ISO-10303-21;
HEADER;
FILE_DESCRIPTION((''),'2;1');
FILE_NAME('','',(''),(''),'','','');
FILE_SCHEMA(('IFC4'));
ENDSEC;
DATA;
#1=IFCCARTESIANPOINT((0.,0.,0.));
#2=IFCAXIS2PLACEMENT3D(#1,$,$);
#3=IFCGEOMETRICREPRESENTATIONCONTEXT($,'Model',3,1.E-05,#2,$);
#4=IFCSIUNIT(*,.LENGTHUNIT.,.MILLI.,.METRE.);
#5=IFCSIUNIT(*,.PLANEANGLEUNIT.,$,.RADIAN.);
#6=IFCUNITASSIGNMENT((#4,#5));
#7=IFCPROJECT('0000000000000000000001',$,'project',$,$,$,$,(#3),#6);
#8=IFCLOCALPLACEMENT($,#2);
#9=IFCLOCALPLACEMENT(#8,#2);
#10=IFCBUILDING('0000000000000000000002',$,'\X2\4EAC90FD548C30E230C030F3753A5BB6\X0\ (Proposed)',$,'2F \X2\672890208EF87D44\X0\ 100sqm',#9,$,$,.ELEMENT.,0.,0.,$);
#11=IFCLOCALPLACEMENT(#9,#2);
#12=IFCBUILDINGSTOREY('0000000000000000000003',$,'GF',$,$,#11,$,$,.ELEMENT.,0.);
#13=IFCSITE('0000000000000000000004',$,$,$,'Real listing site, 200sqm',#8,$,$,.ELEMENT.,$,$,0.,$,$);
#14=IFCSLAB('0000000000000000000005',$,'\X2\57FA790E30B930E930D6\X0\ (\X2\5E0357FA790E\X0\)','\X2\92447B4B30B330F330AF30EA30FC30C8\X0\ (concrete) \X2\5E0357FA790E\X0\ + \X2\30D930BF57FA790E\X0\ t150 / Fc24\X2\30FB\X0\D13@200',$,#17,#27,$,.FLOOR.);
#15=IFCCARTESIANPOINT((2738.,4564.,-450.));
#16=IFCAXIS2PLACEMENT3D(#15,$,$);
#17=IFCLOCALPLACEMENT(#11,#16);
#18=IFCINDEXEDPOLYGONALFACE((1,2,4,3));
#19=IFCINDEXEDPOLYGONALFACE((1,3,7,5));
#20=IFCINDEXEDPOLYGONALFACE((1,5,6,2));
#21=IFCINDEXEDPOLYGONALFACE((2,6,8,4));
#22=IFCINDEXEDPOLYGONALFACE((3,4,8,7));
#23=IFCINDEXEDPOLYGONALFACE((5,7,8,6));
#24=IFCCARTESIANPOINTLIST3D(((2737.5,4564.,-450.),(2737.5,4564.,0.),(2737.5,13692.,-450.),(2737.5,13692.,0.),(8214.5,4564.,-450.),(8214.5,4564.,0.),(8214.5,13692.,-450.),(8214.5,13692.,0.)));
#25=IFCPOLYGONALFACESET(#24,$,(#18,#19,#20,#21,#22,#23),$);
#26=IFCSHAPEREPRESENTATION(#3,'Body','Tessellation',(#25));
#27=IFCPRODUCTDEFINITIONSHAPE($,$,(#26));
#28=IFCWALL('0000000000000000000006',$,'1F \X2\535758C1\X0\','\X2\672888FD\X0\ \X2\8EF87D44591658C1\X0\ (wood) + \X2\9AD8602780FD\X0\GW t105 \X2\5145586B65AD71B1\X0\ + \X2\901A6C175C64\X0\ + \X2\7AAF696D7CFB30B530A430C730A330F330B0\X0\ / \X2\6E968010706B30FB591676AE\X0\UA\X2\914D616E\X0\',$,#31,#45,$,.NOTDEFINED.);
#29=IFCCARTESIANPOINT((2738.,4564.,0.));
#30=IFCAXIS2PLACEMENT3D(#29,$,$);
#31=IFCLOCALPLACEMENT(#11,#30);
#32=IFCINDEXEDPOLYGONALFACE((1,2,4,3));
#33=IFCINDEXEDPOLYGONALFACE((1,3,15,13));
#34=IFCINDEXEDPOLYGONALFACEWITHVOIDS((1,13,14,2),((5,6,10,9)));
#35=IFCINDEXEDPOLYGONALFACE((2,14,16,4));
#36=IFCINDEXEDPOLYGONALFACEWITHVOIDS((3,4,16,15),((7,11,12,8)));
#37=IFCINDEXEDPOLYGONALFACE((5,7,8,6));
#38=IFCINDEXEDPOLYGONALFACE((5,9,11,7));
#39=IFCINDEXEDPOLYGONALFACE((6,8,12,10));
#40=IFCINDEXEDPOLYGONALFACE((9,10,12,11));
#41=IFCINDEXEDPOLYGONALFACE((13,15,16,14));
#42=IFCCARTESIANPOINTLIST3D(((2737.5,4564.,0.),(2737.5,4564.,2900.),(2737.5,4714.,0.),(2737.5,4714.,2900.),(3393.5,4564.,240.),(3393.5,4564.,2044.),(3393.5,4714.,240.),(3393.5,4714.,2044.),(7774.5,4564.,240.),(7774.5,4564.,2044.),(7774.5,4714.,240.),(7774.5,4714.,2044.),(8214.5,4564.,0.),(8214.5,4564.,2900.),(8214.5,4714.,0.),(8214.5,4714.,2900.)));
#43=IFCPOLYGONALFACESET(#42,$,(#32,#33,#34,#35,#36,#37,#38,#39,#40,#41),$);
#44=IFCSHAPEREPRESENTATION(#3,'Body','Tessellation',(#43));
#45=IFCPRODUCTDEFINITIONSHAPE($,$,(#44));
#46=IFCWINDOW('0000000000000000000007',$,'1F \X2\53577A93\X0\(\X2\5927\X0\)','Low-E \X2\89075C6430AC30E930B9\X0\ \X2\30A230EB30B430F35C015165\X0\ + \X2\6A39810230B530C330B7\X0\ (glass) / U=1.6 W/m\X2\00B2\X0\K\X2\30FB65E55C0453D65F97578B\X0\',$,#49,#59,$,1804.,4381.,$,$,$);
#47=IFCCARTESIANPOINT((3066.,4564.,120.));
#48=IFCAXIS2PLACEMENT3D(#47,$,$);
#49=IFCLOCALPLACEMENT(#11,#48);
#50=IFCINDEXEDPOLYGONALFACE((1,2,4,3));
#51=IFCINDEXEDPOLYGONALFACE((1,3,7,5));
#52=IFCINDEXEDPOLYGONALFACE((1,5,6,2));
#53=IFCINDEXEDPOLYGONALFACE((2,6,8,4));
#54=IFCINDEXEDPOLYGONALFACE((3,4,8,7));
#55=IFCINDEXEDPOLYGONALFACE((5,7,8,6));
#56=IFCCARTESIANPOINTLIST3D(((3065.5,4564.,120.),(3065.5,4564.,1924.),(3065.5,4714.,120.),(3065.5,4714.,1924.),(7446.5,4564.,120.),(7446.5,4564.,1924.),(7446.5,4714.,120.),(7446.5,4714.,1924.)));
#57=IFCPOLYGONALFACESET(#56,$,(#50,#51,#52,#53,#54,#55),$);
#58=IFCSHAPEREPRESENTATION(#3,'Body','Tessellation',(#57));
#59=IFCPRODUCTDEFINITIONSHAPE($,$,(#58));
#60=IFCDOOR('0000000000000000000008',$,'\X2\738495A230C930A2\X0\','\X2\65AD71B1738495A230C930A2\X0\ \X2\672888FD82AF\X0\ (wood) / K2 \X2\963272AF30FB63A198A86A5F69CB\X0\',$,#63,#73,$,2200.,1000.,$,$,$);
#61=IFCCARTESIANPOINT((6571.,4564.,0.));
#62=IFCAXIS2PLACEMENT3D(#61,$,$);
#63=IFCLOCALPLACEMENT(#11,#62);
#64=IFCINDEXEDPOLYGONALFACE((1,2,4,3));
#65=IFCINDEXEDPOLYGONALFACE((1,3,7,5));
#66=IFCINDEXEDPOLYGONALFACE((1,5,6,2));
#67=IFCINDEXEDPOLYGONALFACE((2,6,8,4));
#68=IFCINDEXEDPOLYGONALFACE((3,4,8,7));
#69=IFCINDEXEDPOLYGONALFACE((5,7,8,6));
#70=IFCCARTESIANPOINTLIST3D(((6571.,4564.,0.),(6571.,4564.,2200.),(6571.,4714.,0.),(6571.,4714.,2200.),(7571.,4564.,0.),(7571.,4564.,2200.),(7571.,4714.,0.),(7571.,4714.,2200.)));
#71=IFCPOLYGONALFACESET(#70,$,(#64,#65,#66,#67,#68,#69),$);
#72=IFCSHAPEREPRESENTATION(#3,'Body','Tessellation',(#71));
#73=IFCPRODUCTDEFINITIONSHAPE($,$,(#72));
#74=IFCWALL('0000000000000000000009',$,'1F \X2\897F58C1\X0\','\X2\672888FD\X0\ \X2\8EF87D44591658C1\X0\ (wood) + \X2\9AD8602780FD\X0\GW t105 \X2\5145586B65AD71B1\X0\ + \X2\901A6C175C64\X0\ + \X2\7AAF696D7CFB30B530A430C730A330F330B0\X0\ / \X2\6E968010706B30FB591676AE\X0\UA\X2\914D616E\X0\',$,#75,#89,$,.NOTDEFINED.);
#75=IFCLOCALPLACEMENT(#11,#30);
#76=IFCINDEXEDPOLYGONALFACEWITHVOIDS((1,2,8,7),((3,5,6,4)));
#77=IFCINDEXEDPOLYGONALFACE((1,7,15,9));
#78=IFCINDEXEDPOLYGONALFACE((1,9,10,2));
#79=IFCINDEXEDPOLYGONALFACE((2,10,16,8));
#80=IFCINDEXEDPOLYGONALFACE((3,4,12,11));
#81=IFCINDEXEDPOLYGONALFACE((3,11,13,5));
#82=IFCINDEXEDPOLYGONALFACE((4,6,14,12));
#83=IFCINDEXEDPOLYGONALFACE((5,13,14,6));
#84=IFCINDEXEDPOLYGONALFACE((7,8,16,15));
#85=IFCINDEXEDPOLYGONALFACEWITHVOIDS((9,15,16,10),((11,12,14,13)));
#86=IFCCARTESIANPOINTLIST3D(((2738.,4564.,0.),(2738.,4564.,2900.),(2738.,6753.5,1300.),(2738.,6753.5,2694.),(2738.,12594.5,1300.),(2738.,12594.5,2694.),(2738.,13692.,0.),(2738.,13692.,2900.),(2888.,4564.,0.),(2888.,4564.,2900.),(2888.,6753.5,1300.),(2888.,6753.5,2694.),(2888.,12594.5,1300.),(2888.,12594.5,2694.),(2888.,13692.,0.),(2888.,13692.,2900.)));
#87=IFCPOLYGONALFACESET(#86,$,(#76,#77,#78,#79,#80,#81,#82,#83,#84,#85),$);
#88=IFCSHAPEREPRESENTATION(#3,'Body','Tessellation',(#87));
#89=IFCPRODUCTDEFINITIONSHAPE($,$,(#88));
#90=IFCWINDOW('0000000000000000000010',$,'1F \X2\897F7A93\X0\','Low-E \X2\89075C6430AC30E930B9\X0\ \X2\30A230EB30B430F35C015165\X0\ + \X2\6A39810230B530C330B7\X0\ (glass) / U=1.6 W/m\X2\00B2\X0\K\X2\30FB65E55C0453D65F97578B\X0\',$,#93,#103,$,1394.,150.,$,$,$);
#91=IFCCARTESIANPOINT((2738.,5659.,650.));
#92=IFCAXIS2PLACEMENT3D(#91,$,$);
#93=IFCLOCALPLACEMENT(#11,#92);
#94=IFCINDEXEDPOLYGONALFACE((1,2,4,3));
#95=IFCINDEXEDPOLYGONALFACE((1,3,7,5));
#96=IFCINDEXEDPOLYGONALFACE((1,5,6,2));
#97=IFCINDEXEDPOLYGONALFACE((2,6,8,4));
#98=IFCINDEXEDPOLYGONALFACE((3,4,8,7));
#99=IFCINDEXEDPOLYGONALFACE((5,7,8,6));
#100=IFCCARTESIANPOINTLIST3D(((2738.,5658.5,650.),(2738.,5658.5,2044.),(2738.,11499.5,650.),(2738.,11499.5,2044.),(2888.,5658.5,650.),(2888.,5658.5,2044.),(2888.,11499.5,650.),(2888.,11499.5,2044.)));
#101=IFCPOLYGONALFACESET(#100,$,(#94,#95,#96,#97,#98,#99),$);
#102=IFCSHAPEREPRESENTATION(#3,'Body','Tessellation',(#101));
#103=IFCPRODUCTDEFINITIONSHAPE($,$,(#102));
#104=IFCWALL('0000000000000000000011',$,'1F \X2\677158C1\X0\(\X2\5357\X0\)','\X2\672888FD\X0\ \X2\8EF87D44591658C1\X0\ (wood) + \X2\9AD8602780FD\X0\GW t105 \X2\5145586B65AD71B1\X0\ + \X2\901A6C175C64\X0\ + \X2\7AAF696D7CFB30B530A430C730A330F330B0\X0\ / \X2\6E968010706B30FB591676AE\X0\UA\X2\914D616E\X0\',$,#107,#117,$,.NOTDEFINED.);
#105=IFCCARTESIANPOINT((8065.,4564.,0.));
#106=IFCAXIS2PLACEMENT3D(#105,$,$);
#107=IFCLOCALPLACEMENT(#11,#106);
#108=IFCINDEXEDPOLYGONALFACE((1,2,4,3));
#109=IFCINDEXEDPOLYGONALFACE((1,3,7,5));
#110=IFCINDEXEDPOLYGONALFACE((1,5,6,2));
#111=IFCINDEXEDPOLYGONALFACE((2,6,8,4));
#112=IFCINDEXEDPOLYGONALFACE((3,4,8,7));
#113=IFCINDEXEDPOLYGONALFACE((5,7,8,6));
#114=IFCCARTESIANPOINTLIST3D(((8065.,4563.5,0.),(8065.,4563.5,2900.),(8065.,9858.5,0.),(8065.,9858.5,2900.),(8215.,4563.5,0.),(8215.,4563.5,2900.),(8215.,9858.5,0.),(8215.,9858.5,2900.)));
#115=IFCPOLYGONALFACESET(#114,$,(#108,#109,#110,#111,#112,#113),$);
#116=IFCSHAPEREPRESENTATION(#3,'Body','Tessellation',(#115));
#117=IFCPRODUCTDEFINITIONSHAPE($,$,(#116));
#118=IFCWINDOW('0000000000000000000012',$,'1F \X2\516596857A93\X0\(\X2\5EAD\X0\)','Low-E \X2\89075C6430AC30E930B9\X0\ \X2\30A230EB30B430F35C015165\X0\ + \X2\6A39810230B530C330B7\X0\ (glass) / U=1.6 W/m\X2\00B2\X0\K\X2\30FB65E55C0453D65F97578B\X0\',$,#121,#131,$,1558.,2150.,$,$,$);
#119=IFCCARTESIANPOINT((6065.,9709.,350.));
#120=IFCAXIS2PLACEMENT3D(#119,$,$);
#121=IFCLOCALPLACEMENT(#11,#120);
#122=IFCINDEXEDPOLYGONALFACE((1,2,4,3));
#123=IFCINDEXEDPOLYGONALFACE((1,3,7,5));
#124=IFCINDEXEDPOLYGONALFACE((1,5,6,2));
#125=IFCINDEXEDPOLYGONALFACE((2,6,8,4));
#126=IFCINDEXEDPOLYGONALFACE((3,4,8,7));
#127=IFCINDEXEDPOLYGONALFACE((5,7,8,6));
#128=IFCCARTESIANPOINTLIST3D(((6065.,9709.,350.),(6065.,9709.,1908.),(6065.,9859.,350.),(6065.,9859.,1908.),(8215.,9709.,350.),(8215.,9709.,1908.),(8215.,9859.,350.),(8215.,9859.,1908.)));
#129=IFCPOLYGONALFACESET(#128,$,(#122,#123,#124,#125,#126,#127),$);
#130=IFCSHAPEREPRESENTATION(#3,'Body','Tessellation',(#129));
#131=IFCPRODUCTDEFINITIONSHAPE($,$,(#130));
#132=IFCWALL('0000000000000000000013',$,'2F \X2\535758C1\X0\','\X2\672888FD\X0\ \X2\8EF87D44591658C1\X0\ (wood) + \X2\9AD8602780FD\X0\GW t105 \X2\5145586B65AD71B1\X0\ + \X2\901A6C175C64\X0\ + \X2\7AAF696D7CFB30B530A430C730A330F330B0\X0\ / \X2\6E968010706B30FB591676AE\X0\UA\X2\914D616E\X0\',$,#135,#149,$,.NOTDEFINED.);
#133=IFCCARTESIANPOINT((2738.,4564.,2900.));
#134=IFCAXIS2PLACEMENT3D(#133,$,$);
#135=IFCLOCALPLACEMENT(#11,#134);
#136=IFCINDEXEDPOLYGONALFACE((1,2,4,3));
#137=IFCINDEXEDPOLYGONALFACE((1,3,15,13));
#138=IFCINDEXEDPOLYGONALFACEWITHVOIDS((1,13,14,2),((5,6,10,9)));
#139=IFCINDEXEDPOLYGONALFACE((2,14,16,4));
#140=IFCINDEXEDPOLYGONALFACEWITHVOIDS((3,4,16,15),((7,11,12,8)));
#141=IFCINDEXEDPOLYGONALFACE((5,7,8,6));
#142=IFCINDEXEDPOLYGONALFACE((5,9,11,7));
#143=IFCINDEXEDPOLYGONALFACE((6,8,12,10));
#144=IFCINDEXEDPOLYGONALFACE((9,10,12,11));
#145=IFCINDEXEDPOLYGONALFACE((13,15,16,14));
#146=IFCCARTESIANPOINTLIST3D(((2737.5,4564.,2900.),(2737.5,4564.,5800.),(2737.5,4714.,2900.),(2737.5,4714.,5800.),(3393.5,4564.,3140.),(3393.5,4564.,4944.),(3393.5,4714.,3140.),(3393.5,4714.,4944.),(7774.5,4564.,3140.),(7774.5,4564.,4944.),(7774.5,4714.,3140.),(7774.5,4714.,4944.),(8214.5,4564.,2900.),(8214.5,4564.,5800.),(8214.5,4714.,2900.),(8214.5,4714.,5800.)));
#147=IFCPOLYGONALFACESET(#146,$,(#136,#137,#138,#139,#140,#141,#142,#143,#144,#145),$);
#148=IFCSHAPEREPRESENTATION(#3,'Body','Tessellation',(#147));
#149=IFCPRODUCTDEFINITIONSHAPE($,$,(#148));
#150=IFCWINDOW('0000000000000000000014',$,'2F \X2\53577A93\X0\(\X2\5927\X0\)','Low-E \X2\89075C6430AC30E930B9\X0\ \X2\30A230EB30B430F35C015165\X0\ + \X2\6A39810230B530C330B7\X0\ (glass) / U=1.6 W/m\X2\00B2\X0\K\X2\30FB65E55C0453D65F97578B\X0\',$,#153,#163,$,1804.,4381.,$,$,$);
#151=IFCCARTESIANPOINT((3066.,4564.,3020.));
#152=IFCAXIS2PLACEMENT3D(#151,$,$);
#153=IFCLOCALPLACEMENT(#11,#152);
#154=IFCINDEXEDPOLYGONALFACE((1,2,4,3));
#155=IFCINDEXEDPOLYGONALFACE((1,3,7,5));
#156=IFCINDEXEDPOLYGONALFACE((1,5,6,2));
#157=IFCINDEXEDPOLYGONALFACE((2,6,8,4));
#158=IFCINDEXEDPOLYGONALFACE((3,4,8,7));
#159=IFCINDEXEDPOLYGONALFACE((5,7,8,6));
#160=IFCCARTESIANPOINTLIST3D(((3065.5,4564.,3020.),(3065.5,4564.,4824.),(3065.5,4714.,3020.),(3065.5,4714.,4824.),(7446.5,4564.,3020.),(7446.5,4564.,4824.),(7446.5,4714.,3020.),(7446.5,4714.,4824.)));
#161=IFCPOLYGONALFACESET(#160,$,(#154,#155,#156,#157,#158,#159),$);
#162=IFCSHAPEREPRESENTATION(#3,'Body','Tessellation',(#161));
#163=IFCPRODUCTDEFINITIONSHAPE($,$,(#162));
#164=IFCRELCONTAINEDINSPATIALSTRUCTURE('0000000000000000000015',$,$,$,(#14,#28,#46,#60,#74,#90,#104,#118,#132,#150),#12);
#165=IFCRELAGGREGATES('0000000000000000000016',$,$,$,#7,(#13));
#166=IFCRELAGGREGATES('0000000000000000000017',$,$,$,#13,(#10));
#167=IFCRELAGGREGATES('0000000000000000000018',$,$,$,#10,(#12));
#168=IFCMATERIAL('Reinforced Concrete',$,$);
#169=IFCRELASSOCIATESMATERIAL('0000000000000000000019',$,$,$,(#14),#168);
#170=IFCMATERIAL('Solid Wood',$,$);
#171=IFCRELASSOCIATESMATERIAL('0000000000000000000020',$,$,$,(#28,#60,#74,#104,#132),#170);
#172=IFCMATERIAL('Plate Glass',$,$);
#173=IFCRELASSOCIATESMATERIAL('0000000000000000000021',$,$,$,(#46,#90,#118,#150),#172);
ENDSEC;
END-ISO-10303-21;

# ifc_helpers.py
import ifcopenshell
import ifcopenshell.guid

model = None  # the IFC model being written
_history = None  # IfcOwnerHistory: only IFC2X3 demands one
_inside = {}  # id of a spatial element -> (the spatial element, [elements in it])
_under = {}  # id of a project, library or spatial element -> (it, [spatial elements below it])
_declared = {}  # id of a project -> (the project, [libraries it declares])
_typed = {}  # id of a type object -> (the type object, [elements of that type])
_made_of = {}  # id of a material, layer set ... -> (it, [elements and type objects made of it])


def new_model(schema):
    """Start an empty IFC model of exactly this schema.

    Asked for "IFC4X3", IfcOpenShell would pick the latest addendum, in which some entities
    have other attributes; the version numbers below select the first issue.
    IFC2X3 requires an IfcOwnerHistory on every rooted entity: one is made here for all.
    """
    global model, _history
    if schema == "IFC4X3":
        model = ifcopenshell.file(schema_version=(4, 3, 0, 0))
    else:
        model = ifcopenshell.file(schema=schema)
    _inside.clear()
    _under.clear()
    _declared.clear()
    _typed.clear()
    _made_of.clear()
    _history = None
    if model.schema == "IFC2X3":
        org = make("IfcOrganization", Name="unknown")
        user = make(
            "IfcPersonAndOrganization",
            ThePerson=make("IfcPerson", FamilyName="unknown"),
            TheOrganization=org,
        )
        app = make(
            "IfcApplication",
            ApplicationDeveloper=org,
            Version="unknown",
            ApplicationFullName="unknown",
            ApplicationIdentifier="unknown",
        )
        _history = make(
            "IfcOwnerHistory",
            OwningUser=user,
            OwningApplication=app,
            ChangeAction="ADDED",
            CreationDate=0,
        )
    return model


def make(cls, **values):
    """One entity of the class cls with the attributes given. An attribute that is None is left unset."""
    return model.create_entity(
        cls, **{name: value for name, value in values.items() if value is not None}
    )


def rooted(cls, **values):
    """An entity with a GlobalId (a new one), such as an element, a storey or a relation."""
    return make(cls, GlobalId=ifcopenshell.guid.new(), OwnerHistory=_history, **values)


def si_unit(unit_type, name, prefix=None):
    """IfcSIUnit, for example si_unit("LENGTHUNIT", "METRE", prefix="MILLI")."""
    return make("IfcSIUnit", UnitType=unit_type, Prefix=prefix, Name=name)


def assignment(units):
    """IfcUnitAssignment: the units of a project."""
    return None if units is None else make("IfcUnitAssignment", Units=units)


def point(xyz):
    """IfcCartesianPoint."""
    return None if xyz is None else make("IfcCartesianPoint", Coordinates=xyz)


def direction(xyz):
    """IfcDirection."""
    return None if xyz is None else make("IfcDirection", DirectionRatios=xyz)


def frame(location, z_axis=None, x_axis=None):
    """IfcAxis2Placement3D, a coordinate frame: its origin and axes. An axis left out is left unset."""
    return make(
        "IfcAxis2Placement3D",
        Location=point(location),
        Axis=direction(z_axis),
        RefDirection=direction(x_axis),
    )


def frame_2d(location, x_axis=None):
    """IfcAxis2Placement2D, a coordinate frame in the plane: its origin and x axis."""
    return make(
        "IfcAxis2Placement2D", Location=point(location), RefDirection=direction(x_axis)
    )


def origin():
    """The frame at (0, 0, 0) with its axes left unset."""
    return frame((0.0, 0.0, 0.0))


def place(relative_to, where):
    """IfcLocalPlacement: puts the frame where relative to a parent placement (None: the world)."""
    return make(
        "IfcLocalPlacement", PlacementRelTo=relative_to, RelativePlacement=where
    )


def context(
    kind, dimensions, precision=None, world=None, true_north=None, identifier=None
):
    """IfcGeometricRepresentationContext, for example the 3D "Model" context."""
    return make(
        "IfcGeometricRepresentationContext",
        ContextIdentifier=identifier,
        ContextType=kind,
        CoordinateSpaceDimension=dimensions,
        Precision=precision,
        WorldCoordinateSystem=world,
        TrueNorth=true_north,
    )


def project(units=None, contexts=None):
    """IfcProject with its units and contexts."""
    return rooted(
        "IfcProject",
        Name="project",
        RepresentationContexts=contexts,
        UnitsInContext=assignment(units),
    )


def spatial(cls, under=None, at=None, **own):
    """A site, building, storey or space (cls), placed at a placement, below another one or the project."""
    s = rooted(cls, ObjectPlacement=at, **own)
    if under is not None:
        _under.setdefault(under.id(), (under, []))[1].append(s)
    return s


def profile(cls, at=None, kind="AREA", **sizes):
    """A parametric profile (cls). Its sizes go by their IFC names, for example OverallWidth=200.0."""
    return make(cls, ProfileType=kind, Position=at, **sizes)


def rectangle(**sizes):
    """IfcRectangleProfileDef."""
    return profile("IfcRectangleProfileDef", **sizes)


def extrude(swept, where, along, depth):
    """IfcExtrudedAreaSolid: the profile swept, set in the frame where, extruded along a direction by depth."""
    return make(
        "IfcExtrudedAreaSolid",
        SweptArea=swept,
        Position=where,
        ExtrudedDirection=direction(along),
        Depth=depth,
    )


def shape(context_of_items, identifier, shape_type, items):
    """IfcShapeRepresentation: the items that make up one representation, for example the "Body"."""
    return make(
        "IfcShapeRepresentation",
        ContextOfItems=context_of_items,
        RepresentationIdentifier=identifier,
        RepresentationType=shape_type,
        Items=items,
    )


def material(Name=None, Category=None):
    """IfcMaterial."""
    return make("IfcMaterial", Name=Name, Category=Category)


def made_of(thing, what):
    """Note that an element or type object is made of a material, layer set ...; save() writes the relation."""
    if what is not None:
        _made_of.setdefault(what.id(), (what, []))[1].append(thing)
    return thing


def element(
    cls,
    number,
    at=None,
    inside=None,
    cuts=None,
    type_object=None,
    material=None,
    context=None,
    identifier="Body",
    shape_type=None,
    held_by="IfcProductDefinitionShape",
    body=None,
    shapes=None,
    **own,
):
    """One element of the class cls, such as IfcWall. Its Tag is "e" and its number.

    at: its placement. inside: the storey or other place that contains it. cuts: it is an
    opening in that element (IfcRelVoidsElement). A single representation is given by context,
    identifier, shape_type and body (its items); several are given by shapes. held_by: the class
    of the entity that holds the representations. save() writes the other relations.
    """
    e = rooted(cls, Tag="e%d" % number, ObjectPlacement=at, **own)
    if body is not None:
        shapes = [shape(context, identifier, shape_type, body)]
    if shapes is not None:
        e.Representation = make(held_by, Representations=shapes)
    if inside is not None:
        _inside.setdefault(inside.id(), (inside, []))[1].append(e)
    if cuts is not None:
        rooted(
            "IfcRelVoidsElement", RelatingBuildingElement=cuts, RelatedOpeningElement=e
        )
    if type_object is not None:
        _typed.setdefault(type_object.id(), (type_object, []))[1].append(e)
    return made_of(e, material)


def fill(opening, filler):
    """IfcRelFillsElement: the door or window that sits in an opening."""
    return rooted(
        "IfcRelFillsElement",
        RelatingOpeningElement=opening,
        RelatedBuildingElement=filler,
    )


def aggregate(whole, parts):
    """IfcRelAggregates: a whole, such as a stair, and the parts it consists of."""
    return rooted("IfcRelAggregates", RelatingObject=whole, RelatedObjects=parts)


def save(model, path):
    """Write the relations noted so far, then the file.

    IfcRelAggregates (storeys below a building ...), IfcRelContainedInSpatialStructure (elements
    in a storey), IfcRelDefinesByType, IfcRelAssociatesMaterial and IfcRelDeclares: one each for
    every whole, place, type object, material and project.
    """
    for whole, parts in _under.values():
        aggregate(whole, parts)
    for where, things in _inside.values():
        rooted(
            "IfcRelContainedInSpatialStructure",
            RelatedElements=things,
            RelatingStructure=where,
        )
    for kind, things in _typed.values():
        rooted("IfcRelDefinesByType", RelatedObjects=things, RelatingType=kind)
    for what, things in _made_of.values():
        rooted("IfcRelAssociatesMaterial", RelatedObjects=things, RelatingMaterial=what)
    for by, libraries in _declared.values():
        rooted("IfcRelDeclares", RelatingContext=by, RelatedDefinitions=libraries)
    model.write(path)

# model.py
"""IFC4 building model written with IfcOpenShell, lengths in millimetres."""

from ifc_helpers import new_model, si_unit, frame, frame_2d, origin, place, context, project, spatial, rectangle, extrude, material, element, fill, save


model = new_model("IFC4")

# Units and contexts
model_context = context("Model", 3, precision=1e-05, world=origin())
ifc_project = project(units=[si_unit("LENGTHUNIT", "METRE", prefix="MILLI"), si_unit("PLANEANGLEUNIT", "RADIAN")], contexts=[model_context])

# Site, building, storey
site_placement = place(None, origin())
site = spatial("IfcSite", under=ifc_project, at=site_placement, ObjectType="Real listing site, 200sqm", CompositionType="ELEMENT", RefElevation=0.0)
building_placement = place(site_placement, origin())
building = spatial("IfcBuilding", under=site, at=building_placement, Name="京都和モダン町家 (Proposed)", ObjectType="2F 木造軸組 100sqm", CompositionType="ELEMENT", ElevationOfRefHeight=0.0, ElevationOfTerrain=0.0)
storey_placement = place(building_placement, origin())
storey = spatial("IfcBuildingStorey", under=building, at=storey_placement, Name="GF", CompositionType="ELEMENT", Elevation=0.0)

# Slab
ifc_material_1 = material(Name="Reinforced Concrete")
slab_1_placement = place(storey_placement, frame((2738.0, 4564.0, -450.0)))
element("IfcSlab", 1, at=slab_1_placement, inside=storey, material=ifc_material_1, Name="基礎スラブ (布基礎)", Description="鉄筋コンクリート (concrete) 布基礎 + ベタ基礎 t150 / Fc24・D13@200", PredefinedType="FLOOR", context=model_context, shape_type="SweptSolid", body=[
    extrude(rectangle(XDim=5477.0, YDim=9128.0, at=frame_2d((2738.0, 4564.0))), frame((2738.0, 4564.0, -450.0)), (0.0, 0.0, 1.0), 450.0),
])
ifc_material_2 = material(Name="Solid Wood")

# Wall, openings, window, door
wall_1_placement = place(storey_placement, frame((2738.0, 4564.0, 0.0)))
wall_1 = element("IfcWall", 2, at=wall_1_placement, inside=storey, material=ifc_material_2, Name="1F 南壁", Description="木製 軸組外壁 (wood) + 高性能GW t105 充填断熱 + 通気層 + 窯業系サイディング / 準耐火・外皮UA配慮", PredefinedType="NOTDEFINED", context=model_context, shape_type="SweptSolid", body=[
    extrude(rectangle(XDim=5477.0, YDim=150.0, at=frame_2d((2738.0, 75.0))), frame((2738.0, 4564.0, 0.0)), (0.0, 0.0, 1.0), 2900.0),
])
opening_1_placement = place(storey_placement, frame((3066.0, 4564.0, 120.0)))
opening_1 = element("IfcOpeningElement", 3, at=opening_1_placement, cuts=wall_1, PredefinedType="NOTDEFINED", context=model_context, shape_type="SweptSolid", body=[
    extrude(rectangle(XDim=4381.0, YDim=150.0, at=frame_2d((2190.0, 75.0))), frame((3066.0, 4564.0, 120.0)), (0.0, 0.0, 1.0), 1804.0),
])
opening_2_placement = place(storey_placement, frame((6571.0, 4564.0, 0.0)))
opening_2 = element("IfcOpeningElement", 4, at=opening_2_placement, cuts=wall_1, PredefinedType="NOTDEFINED", context=model_context, shape_type="SweptSolid", body=[
    extrude(rectangle(XDim=1000.0, YDim=150.0, at=frame_2d((500.0, 75.0))), frame((6571.0, 4564.0, 0.0)), (0.0, 0.0, 1.0), 2200.0),
])
ifc_material_3 = material(Name="Plate Glass")
window_1_placement = place(storey_placement, frame((3066.0, 4564.0, 120.0)))
window_1 = element("IfcWindow", 5, at=window_1_placement, inside=storey, material=ifc_material_3, Name="1F 南窓(大)", Description="Low-E 複層ガラス アルゴン封入 + 樹脂サッシ (glass) / U=1.6 W/m²K・日射取得型", OverallHeight=1804.0, OverallWidth=4381.0, context=model_context, shape_type="SweptSolid", body=[
    extrude(rectangle(XDim=4381.0, YDim=150.0, at=frame_2d((2190.0, 75.0))), frame((3066.0, 4564.0, 120.0)), (0.0, 0.0, 1.0), 1804.0),
])
fill(opening_1, window_1)
door_placement = place(storey_placement, frame((6571.0, 4564.0, 0.0)))
door = element("IfcDoor", 6, at=door_placement, inside=storey, material=ifc_material_2, Name="玄関ドア", Description="断熱玄関ドア 木製芯 (wood) / K2 防犯・採風機構", OverallHeight=2200.0, OverallWidth=1000.0, context=model_context, shape_type="SweptSolid", body=[
    extrude(rectangle(XDim=1000.0, YDim=150.0, at=frame_2d((500.0, 75.0))), frame((6571.0, 4564.0, 0.0)), (0.0, 0.0, 1.0), 2200.0),
])
fill(opening_2, door)

# Walls, openings, windows
wall_2_placement = place(storey_placement, frame((2738.0, 4564.0, 0.0)))
wall_2 = element("IfcWall", 7, at=wall_2_placement, inside=storey, material=ifc_material_2, Name="1F 西壁", Description="木製 軸組外壁 (wood) + 高性能GW t105 充填断熱 + 通気層 + 窯業系サイディング / 準耐火・外皮UA配慮", PredefinedType="NOTDEFINED", context=model_context, shape_type="SweptSolid", body=[
    extrude(rectangle(XDim=150.0, YDim=9128.0, at=frame_2d((75.0, 4564.0))), frame((2738.0, 4564.0, 0.0)), (0.0, 0.0, 1.0), 2900.0),
])
opening_3_placement = place(storey_placement, frame((2738.0, 5659.0, 650.0)))
opening_3 = element("IfcOpeningElement", 8, at=opening_3_placement, cuts=wall_2, PredefinedType="NOTDEFINED", context=model_context, shape_type="SweptSolid", body=[
    extrude(rectangle(XDim=150.0, YDim=5841.0, at=frame_2d((75.0, 2920.0))), frame((2738.0, 5659.0, 650.0)), (0.0, 0.0, 1.0), 1394.0),
])
window_2_placement = place(storey_placement, frame((2738.0, 5659.0, 650.0)))
window_2 = element("IfcWindow", 9, at=window_2_placement, inside=storey, material=ifc_material_3, Name="1F 西窓", Description="Low-E 複層ガラス アルゴン封入 + 樹脂サッシ (glass) / U=1.6 W/m²K・日射取得型", OverallHeight=1394.0, OverallWidth=150.0, context=model_context, shape_type="SweptSolid", body=[
    extrude(rectangle(XDim=150.0, YDim=5841.0, at=frame_2d((75.0, 2920.0))), frame((2738.0, 5659.0, 650.0)), (0.0, 0.0, 1.0), 1394.0),
])
fill(opening_3, window_2)
wall_3_placement = place(storey_placement, frame((8065.0, 4564.0, 0.0)))
wall_3 = element("IfcWall", 10, at=wall_3_placement, inside=storey, material=ifc_material_2, Name="1F 東壁(南)", Description="木製 軸組外壁 (wood) + 高性能GW t105 充填断熱 + 通気層 + 窯業系サイディング / 準耐火・外皮UA配慮", PredefinedType="NOTDEFINED", context=model_context, shape_type="SweptSolid", body=[
    extrude(rectangle(XDim=150.0, YDim=5295.0, at=frame_2d((75.0, 2647.0))), frame((8065.0, 4564.0, 0.0)), (0.0, 0.0, 1.0), 2900.0),
])
opening_4_placement = place(storey_placement, frame((6065.0, 9709.0, 350.0)))
opening_4 = element("IfcOpeningElement", 11, at=opening_4_placement, cuts=wall_3, PredefinedType="NOTDEFINED", context=model_context, shape_type="SweptSolid", body=[
    extrude(rectangle(XDim=2150.0, YDim=150.0, at=frame_2d((1075.0, 75.0))), frame((6065.0, 9709.0, 350.0)), (0.0, 0.0, 1.0), 1558.0),
])
window_3_placement = place(storey_placement, frame((6065.0, 9709.0, 350.0)))
window_3 = element("IfcWindow", 12, at=window_3_placement, inside=storey, material=ifc_material_3, Name="1F 入隅窓(庭)", Description="Low-E 複層ガラス アルゴン封入 + 樹脂サッシ (glass) / U=1.6 W/m²K・日射取得型", OverallHeight=1558.0, OverallWidth=2150.0, context=model_context, shape_type="SweptSolid", body=[
    extrude(rectangle(XDim=2150.0, YDim=150.0, at=frame_2d((1075.0, 75.0))), frame((6065.0, 9709.0, 350.0)), (0.0, 0.0, 1.0), 1558.0),
])
fill(opening_4, window_3)

# Wall, opening, window
wall_4_placement = place(storey_placement, frame((2738.0, 4564.0, 2900.0)))
wall_4 = element("IfcWall", 13, at=wall_4_placement, inside=storey, material=ifc_material_2, Name="2F 南壁", Description="木製 軸組外壁 (wood) + 高性能GW t105 充填断熱 + 通気層 + 窯業系サイディング / 準耐火・外皮UA配慮", PredefinedType="NOTDEFINED", context=model_context, shape_type="SweptSolid", body=[
    extrude(rectangle(XDim=5477.0, YDim=150.0, at=frame_2d((2738.0, 75.0))), frame((2738.0, 4564.0, 2900.0)), (0.0, 0.0, 1.0), 2900.0),
])
opening_5_placement = place(storey_placement, frame((3066.0, 4564.0, 3020.0)))
opening_5 = element("IfcOpeningElement", 14, at=opening_5_placement, cuts=wall_4, PredefinedType="NOTDEFINED", context=model_context, shape_type="SweptSolid", body=[
    extrude(rectangle(XDim=4381.0, YDim=150.0, at=frame_2d((2190.0, 75.0))), frame((3066.0, 4564.0, 3020.0)), (0.0, 0.0, 1.0), 1804.0),
])
window_4_placement = place(storey_placement, frame((3066.0, 4564.0, 3020.0)))
window_4 = element("IfcWindow", 15, at=window_4_placement, inside=storey, material=ifc_material_3, Name="2F 南窓(大)", Description="Low-E 複層ガラス アルゴン封入 + 樹脂サッシ (glass) / U=1.6 W/m²K・日射取得型", OverallHeight=1804.0, OverallWidth=4381.0, context=model_context, shape_type="SweptSolid", body=[
    extrude(rectangle(XDim=4381.0, YDim=150.0, at=frame_2d((2190.0, 75.0))), frame((3066.0, 4564.0, 3020.0)), (0.0, 0.0, 1.0), 1804.0),
])
fill(opening_5, window_4)

save(model, "model.ifc")
